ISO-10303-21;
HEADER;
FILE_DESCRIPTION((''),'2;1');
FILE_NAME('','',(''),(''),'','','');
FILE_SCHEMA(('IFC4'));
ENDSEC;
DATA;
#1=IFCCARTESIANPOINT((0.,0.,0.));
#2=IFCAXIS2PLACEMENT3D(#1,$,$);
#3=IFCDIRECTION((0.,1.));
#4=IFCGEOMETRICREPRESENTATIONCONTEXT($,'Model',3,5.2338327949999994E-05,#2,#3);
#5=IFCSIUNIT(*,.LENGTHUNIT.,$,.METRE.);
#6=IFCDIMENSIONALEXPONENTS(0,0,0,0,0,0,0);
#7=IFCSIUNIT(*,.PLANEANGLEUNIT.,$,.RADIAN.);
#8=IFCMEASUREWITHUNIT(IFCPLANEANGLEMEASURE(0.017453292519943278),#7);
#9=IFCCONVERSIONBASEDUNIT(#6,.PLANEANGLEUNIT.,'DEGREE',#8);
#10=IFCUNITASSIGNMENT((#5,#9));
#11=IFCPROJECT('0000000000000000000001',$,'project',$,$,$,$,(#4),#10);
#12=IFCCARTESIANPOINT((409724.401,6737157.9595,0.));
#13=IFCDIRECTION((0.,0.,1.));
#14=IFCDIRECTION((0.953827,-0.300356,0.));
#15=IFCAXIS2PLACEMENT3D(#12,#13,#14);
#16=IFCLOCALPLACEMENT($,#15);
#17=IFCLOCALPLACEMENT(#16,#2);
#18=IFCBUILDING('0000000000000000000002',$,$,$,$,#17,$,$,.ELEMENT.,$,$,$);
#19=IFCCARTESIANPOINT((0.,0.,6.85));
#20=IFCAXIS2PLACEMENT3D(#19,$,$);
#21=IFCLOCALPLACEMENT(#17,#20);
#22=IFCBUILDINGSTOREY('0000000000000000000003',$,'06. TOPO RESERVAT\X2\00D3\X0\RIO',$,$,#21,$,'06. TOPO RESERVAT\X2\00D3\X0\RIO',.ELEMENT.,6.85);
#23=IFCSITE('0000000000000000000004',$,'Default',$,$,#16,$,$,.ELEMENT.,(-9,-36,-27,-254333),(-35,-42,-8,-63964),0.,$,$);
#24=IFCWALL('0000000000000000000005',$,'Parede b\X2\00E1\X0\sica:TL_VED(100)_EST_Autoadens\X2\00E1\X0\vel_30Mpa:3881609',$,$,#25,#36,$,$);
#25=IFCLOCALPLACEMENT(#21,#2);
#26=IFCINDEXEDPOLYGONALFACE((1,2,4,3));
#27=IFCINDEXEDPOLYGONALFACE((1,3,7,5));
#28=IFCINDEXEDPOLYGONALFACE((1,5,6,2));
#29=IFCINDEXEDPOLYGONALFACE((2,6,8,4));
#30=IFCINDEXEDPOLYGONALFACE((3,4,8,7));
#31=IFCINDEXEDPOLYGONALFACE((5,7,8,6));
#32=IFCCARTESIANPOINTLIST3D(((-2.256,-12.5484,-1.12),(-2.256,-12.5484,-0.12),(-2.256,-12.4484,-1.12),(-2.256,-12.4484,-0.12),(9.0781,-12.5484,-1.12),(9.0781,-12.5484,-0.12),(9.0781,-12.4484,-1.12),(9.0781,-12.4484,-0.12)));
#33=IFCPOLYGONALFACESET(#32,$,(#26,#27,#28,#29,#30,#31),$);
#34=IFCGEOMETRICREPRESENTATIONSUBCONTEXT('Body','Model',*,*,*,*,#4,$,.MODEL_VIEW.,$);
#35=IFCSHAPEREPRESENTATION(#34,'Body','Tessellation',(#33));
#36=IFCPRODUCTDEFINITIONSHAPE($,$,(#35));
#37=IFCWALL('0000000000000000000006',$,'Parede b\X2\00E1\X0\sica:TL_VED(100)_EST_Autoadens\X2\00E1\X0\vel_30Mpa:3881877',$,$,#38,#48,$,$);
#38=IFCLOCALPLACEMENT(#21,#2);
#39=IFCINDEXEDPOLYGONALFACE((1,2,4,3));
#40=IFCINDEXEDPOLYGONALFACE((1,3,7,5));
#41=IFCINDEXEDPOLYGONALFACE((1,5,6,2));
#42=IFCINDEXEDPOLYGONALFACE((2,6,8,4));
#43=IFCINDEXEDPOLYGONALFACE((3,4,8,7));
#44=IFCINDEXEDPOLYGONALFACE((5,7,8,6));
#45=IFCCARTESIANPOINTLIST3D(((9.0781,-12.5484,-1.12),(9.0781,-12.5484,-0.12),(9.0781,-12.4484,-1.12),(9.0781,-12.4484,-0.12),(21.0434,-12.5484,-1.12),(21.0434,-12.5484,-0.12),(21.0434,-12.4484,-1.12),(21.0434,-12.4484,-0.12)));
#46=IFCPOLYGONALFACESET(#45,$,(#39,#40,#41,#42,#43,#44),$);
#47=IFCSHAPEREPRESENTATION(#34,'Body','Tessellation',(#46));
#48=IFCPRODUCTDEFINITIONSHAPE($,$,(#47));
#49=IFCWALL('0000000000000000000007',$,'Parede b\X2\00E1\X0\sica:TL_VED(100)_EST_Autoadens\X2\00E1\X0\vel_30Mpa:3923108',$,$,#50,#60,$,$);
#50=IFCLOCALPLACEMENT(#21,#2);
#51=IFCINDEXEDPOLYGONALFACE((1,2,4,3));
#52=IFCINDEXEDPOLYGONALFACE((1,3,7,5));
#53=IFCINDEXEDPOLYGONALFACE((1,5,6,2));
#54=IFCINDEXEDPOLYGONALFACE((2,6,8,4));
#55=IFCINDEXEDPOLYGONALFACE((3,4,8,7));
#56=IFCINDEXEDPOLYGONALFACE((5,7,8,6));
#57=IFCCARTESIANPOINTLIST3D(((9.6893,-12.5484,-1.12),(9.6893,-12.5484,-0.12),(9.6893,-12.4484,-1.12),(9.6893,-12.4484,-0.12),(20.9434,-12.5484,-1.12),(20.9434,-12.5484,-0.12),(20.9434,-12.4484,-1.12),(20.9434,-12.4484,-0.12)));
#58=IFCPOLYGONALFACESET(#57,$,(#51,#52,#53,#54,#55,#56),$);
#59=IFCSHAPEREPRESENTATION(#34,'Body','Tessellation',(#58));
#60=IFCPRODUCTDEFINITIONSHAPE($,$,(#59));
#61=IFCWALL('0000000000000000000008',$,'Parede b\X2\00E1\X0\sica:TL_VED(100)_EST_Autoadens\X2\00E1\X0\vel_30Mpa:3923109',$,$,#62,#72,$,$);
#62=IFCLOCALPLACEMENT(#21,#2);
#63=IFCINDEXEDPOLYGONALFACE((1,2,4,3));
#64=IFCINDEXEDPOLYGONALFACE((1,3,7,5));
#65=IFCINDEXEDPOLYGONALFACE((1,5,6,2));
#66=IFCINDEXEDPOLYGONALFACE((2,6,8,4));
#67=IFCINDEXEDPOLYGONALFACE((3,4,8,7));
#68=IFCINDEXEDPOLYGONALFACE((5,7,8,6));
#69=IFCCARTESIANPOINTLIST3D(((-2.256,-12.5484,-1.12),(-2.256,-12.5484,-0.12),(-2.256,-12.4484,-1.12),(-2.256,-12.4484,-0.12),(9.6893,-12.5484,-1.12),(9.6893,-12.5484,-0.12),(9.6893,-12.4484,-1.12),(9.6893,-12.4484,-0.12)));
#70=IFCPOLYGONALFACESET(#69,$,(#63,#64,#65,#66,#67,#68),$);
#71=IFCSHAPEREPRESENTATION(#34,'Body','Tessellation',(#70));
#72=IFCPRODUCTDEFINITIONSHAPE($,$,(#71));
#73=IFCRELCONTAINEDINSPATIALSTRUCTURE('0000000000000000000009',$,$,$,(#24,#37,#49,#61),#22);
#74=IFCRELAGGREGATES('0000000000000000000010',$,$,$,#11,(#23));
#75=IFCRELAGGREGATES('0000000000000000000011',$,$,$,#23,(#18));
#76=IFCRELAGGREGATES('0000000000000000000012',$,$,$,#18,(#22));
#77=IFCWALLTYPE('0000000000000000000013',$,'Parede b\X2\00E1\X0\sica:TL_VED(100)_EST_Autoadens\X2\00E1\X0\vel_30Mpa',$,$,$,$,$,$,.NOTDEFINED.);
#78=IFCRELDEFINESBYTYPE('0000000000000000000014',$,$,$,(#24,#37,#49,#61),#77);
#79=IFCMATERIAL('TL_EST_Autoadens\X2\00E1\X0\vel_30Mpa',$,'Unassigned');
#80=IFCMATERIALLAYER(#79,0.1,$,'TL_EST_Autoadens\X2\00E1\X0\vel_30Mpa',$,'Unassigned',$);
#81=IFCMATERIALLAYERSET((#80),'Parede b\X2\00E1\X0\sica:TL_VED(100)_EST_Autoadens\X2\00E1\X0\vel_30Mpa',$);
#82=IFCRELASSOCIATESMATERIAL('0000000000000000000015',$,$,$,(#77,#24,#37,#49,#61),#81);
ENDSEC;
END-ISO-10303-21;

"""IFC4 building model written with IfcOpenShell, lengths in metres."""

from ifc_helpers import new_model, entity, si_unit, converted_unit, direction, frame, frame_2d, origin, place, context, subcontext, project, spatial, rectangle, extrude, material, layer, layer_set, layer_usage, type_object, element, save


model = new_model("IFC4")

# Units and contexts
model_context = context("Model", 3, precision=5.2338327949999994e-05, world=origin(), true_north=direction((0.0, 1.0)))
body_context = subcontext(model_context, "Body", "Model", "MODEL_VIEW")
ifc_project = project(units=[si_unit("LENGTHUNIT", "METRE"), converted_unit("PLANEANGLEUNIT", "DEGREE", entity("IfcPlaneAngleMeasure", 0.017453292519943278), si_unit("PLANEANGLEUNIT", "RADIAN"), dimensions=[0, 0, 0, 0, 0, 0, 0])], contexts=[model_context])

# Site, building, storey
site_placement = place(None, frame((409724.401, 6737157.9595, 0.0), z_axis=(0.0, 0.0, 1.0), x_axis=(0.953827, -0.300356, 0.0)))
site = spatial("IfcSite", under=ifc_project, at=site_placement, Name="Default", CompositionType="ELEMENT", RefLatitude=(-9, -36, -27, -254333), RefLongitude=(-35, -42, -8, -63964), RefElevation=0.0)
building_placement = place(site_placement, origin())
building = spatial("IfcBuilding", under=site, at=building_placement, CompositionType="ELEMENT")
storey_placement = place(building_placement, frame((0.0, 0.0, 6.85)))
storey = spatial("IfcBuildingStorey", under=building, at=storey_placement, Name="06. TOPO RESERVATÓRIO", LongName="06. TOPO RESERVATÓRIO", CompositionType="ELEMENT", Elevation=6.85)

# Walls
ifc_material_1 = material(Name="TL_EST_Autoadensável_30Mpa", Category="Unassigned")
ifc_layer = layer(ifc_material_1, 0.1, Name="TL_EST_Autoadensável_30Mpa", Category="Unassigned")
ifc_layer_set = layer_set([ifc_layer], Name="Parede básica:TL_VED(100)_EST_Autoadensável_30Mpa")
ifc_layer_usage_1 = layer_usage(ifc_layer_set, "AXIS2", "NEGATIVE", 0.05)
wall_type = type_object("IfcWallType", Name="Parede básica:TL_VED(100)_EST_Autoadensável_30Mpa", PredefinedType="NOTDEFINED", material=ifc_layer_set)
wall_1_placement = place(storey_placement, frame((9.0781, -12.4984, -1.12), z_axis=(0.0, 0.0, 1.0), x_axis=(-1.0, 0.0, 0.0)))
element("IfcWall", 1, at=wall_1_placement, inside=storey, type_object=wall_type, material=ifc_layer_usage_1, Name="Parede básica:TL_VED(100)_EST_Autoadensável_30Mpa:3881609", context=body_context, shape_type="SweptSolid", body=[
    extrude(rectangle(XDim=11.3341, YDim=0.1, at=frame_2d((5.6671, 0.0), x_axis=(-1.0, 0.0))), origin(), (0.0, 0.0, 1.0), 1.0),
])
ifc_layer_usage_2 = layer_usage(ifc_layer_set, "AXIS2", "POSITIVE", -0.05)
wall_2_placement = place(storey_placement, frame((9.0781, -12.4984, -1.12)))
element("IfcWall", 2, at=wall_2_placement, inside=storey, type_object=wall_type, material=ifc_layer_usage_2, Name="Parede básica:TL_VED(100)_EST_Autoadensável_30Mpa:3881877", context=body_context, shape_type="SweptSolid", body=[
    extrude(rectangle(XDim=11.9653, YDim=0.1, at=frame_2d((5.9826, 0.0), x_axis=(-1.0, 0.0))), origin(), (0.0, 0.0, 1.0), 1.0),
])
ifc_layer_usage_3 = layer_usage(ifc_layer_set, "AXIS2", "POSITIVE", -0.05)
wall_3_placement = place(storey_placement, frame((9.6893, -12.4984, -1.12)))
element("IfcWall", 3, at=wall_3_placement, inside=storey, type_object=wall_type, material=ifc_layer_usage_3, Name="Parede básica:TL_VED(100)_EST_Autoadensável_30Mpa:3923108", context=body_context, shape_type="SweptSolid", body=[
    extrude(rectangle(XDim=11.2541, YDim=0.1, at=frame_2d((5.6271, 0.0), x_axis=(-1.0, 0.0))), origin(), (0.0, 0.0, 1.0), 1.0),
])
ifc_layer_usage_4 = layer_usage(ifc_layer_set, "AXIS2", "NEGATIVE", 0.05)
wall_4_placement = place(storey_placement, frame((9.6893, -12.4984, -1.12), z_axis=(0.0, 0.0, 1.0), x_axis=(-1.0, 0.0, 0.0)))
element("IfcWall", 4, at=wall_4_placement, inside=storey, type_object=wall_type, material=ifc_layer_usage_4, Name="Parede básica:TL_VED(100)_EST_Autoadensável_30Mpa:3923109", context=body_context, shape_type="SweptSolid", body=[
    extrude(rectangle(XDim=11.9453, YDim=0.1, at=frame_2d((5.9726, 0.0), x_axis=(-1.0, 0.0))), origin(), (0.0, 0.0, 1.0), 1.0),
])

save(model, "model.ifc")
